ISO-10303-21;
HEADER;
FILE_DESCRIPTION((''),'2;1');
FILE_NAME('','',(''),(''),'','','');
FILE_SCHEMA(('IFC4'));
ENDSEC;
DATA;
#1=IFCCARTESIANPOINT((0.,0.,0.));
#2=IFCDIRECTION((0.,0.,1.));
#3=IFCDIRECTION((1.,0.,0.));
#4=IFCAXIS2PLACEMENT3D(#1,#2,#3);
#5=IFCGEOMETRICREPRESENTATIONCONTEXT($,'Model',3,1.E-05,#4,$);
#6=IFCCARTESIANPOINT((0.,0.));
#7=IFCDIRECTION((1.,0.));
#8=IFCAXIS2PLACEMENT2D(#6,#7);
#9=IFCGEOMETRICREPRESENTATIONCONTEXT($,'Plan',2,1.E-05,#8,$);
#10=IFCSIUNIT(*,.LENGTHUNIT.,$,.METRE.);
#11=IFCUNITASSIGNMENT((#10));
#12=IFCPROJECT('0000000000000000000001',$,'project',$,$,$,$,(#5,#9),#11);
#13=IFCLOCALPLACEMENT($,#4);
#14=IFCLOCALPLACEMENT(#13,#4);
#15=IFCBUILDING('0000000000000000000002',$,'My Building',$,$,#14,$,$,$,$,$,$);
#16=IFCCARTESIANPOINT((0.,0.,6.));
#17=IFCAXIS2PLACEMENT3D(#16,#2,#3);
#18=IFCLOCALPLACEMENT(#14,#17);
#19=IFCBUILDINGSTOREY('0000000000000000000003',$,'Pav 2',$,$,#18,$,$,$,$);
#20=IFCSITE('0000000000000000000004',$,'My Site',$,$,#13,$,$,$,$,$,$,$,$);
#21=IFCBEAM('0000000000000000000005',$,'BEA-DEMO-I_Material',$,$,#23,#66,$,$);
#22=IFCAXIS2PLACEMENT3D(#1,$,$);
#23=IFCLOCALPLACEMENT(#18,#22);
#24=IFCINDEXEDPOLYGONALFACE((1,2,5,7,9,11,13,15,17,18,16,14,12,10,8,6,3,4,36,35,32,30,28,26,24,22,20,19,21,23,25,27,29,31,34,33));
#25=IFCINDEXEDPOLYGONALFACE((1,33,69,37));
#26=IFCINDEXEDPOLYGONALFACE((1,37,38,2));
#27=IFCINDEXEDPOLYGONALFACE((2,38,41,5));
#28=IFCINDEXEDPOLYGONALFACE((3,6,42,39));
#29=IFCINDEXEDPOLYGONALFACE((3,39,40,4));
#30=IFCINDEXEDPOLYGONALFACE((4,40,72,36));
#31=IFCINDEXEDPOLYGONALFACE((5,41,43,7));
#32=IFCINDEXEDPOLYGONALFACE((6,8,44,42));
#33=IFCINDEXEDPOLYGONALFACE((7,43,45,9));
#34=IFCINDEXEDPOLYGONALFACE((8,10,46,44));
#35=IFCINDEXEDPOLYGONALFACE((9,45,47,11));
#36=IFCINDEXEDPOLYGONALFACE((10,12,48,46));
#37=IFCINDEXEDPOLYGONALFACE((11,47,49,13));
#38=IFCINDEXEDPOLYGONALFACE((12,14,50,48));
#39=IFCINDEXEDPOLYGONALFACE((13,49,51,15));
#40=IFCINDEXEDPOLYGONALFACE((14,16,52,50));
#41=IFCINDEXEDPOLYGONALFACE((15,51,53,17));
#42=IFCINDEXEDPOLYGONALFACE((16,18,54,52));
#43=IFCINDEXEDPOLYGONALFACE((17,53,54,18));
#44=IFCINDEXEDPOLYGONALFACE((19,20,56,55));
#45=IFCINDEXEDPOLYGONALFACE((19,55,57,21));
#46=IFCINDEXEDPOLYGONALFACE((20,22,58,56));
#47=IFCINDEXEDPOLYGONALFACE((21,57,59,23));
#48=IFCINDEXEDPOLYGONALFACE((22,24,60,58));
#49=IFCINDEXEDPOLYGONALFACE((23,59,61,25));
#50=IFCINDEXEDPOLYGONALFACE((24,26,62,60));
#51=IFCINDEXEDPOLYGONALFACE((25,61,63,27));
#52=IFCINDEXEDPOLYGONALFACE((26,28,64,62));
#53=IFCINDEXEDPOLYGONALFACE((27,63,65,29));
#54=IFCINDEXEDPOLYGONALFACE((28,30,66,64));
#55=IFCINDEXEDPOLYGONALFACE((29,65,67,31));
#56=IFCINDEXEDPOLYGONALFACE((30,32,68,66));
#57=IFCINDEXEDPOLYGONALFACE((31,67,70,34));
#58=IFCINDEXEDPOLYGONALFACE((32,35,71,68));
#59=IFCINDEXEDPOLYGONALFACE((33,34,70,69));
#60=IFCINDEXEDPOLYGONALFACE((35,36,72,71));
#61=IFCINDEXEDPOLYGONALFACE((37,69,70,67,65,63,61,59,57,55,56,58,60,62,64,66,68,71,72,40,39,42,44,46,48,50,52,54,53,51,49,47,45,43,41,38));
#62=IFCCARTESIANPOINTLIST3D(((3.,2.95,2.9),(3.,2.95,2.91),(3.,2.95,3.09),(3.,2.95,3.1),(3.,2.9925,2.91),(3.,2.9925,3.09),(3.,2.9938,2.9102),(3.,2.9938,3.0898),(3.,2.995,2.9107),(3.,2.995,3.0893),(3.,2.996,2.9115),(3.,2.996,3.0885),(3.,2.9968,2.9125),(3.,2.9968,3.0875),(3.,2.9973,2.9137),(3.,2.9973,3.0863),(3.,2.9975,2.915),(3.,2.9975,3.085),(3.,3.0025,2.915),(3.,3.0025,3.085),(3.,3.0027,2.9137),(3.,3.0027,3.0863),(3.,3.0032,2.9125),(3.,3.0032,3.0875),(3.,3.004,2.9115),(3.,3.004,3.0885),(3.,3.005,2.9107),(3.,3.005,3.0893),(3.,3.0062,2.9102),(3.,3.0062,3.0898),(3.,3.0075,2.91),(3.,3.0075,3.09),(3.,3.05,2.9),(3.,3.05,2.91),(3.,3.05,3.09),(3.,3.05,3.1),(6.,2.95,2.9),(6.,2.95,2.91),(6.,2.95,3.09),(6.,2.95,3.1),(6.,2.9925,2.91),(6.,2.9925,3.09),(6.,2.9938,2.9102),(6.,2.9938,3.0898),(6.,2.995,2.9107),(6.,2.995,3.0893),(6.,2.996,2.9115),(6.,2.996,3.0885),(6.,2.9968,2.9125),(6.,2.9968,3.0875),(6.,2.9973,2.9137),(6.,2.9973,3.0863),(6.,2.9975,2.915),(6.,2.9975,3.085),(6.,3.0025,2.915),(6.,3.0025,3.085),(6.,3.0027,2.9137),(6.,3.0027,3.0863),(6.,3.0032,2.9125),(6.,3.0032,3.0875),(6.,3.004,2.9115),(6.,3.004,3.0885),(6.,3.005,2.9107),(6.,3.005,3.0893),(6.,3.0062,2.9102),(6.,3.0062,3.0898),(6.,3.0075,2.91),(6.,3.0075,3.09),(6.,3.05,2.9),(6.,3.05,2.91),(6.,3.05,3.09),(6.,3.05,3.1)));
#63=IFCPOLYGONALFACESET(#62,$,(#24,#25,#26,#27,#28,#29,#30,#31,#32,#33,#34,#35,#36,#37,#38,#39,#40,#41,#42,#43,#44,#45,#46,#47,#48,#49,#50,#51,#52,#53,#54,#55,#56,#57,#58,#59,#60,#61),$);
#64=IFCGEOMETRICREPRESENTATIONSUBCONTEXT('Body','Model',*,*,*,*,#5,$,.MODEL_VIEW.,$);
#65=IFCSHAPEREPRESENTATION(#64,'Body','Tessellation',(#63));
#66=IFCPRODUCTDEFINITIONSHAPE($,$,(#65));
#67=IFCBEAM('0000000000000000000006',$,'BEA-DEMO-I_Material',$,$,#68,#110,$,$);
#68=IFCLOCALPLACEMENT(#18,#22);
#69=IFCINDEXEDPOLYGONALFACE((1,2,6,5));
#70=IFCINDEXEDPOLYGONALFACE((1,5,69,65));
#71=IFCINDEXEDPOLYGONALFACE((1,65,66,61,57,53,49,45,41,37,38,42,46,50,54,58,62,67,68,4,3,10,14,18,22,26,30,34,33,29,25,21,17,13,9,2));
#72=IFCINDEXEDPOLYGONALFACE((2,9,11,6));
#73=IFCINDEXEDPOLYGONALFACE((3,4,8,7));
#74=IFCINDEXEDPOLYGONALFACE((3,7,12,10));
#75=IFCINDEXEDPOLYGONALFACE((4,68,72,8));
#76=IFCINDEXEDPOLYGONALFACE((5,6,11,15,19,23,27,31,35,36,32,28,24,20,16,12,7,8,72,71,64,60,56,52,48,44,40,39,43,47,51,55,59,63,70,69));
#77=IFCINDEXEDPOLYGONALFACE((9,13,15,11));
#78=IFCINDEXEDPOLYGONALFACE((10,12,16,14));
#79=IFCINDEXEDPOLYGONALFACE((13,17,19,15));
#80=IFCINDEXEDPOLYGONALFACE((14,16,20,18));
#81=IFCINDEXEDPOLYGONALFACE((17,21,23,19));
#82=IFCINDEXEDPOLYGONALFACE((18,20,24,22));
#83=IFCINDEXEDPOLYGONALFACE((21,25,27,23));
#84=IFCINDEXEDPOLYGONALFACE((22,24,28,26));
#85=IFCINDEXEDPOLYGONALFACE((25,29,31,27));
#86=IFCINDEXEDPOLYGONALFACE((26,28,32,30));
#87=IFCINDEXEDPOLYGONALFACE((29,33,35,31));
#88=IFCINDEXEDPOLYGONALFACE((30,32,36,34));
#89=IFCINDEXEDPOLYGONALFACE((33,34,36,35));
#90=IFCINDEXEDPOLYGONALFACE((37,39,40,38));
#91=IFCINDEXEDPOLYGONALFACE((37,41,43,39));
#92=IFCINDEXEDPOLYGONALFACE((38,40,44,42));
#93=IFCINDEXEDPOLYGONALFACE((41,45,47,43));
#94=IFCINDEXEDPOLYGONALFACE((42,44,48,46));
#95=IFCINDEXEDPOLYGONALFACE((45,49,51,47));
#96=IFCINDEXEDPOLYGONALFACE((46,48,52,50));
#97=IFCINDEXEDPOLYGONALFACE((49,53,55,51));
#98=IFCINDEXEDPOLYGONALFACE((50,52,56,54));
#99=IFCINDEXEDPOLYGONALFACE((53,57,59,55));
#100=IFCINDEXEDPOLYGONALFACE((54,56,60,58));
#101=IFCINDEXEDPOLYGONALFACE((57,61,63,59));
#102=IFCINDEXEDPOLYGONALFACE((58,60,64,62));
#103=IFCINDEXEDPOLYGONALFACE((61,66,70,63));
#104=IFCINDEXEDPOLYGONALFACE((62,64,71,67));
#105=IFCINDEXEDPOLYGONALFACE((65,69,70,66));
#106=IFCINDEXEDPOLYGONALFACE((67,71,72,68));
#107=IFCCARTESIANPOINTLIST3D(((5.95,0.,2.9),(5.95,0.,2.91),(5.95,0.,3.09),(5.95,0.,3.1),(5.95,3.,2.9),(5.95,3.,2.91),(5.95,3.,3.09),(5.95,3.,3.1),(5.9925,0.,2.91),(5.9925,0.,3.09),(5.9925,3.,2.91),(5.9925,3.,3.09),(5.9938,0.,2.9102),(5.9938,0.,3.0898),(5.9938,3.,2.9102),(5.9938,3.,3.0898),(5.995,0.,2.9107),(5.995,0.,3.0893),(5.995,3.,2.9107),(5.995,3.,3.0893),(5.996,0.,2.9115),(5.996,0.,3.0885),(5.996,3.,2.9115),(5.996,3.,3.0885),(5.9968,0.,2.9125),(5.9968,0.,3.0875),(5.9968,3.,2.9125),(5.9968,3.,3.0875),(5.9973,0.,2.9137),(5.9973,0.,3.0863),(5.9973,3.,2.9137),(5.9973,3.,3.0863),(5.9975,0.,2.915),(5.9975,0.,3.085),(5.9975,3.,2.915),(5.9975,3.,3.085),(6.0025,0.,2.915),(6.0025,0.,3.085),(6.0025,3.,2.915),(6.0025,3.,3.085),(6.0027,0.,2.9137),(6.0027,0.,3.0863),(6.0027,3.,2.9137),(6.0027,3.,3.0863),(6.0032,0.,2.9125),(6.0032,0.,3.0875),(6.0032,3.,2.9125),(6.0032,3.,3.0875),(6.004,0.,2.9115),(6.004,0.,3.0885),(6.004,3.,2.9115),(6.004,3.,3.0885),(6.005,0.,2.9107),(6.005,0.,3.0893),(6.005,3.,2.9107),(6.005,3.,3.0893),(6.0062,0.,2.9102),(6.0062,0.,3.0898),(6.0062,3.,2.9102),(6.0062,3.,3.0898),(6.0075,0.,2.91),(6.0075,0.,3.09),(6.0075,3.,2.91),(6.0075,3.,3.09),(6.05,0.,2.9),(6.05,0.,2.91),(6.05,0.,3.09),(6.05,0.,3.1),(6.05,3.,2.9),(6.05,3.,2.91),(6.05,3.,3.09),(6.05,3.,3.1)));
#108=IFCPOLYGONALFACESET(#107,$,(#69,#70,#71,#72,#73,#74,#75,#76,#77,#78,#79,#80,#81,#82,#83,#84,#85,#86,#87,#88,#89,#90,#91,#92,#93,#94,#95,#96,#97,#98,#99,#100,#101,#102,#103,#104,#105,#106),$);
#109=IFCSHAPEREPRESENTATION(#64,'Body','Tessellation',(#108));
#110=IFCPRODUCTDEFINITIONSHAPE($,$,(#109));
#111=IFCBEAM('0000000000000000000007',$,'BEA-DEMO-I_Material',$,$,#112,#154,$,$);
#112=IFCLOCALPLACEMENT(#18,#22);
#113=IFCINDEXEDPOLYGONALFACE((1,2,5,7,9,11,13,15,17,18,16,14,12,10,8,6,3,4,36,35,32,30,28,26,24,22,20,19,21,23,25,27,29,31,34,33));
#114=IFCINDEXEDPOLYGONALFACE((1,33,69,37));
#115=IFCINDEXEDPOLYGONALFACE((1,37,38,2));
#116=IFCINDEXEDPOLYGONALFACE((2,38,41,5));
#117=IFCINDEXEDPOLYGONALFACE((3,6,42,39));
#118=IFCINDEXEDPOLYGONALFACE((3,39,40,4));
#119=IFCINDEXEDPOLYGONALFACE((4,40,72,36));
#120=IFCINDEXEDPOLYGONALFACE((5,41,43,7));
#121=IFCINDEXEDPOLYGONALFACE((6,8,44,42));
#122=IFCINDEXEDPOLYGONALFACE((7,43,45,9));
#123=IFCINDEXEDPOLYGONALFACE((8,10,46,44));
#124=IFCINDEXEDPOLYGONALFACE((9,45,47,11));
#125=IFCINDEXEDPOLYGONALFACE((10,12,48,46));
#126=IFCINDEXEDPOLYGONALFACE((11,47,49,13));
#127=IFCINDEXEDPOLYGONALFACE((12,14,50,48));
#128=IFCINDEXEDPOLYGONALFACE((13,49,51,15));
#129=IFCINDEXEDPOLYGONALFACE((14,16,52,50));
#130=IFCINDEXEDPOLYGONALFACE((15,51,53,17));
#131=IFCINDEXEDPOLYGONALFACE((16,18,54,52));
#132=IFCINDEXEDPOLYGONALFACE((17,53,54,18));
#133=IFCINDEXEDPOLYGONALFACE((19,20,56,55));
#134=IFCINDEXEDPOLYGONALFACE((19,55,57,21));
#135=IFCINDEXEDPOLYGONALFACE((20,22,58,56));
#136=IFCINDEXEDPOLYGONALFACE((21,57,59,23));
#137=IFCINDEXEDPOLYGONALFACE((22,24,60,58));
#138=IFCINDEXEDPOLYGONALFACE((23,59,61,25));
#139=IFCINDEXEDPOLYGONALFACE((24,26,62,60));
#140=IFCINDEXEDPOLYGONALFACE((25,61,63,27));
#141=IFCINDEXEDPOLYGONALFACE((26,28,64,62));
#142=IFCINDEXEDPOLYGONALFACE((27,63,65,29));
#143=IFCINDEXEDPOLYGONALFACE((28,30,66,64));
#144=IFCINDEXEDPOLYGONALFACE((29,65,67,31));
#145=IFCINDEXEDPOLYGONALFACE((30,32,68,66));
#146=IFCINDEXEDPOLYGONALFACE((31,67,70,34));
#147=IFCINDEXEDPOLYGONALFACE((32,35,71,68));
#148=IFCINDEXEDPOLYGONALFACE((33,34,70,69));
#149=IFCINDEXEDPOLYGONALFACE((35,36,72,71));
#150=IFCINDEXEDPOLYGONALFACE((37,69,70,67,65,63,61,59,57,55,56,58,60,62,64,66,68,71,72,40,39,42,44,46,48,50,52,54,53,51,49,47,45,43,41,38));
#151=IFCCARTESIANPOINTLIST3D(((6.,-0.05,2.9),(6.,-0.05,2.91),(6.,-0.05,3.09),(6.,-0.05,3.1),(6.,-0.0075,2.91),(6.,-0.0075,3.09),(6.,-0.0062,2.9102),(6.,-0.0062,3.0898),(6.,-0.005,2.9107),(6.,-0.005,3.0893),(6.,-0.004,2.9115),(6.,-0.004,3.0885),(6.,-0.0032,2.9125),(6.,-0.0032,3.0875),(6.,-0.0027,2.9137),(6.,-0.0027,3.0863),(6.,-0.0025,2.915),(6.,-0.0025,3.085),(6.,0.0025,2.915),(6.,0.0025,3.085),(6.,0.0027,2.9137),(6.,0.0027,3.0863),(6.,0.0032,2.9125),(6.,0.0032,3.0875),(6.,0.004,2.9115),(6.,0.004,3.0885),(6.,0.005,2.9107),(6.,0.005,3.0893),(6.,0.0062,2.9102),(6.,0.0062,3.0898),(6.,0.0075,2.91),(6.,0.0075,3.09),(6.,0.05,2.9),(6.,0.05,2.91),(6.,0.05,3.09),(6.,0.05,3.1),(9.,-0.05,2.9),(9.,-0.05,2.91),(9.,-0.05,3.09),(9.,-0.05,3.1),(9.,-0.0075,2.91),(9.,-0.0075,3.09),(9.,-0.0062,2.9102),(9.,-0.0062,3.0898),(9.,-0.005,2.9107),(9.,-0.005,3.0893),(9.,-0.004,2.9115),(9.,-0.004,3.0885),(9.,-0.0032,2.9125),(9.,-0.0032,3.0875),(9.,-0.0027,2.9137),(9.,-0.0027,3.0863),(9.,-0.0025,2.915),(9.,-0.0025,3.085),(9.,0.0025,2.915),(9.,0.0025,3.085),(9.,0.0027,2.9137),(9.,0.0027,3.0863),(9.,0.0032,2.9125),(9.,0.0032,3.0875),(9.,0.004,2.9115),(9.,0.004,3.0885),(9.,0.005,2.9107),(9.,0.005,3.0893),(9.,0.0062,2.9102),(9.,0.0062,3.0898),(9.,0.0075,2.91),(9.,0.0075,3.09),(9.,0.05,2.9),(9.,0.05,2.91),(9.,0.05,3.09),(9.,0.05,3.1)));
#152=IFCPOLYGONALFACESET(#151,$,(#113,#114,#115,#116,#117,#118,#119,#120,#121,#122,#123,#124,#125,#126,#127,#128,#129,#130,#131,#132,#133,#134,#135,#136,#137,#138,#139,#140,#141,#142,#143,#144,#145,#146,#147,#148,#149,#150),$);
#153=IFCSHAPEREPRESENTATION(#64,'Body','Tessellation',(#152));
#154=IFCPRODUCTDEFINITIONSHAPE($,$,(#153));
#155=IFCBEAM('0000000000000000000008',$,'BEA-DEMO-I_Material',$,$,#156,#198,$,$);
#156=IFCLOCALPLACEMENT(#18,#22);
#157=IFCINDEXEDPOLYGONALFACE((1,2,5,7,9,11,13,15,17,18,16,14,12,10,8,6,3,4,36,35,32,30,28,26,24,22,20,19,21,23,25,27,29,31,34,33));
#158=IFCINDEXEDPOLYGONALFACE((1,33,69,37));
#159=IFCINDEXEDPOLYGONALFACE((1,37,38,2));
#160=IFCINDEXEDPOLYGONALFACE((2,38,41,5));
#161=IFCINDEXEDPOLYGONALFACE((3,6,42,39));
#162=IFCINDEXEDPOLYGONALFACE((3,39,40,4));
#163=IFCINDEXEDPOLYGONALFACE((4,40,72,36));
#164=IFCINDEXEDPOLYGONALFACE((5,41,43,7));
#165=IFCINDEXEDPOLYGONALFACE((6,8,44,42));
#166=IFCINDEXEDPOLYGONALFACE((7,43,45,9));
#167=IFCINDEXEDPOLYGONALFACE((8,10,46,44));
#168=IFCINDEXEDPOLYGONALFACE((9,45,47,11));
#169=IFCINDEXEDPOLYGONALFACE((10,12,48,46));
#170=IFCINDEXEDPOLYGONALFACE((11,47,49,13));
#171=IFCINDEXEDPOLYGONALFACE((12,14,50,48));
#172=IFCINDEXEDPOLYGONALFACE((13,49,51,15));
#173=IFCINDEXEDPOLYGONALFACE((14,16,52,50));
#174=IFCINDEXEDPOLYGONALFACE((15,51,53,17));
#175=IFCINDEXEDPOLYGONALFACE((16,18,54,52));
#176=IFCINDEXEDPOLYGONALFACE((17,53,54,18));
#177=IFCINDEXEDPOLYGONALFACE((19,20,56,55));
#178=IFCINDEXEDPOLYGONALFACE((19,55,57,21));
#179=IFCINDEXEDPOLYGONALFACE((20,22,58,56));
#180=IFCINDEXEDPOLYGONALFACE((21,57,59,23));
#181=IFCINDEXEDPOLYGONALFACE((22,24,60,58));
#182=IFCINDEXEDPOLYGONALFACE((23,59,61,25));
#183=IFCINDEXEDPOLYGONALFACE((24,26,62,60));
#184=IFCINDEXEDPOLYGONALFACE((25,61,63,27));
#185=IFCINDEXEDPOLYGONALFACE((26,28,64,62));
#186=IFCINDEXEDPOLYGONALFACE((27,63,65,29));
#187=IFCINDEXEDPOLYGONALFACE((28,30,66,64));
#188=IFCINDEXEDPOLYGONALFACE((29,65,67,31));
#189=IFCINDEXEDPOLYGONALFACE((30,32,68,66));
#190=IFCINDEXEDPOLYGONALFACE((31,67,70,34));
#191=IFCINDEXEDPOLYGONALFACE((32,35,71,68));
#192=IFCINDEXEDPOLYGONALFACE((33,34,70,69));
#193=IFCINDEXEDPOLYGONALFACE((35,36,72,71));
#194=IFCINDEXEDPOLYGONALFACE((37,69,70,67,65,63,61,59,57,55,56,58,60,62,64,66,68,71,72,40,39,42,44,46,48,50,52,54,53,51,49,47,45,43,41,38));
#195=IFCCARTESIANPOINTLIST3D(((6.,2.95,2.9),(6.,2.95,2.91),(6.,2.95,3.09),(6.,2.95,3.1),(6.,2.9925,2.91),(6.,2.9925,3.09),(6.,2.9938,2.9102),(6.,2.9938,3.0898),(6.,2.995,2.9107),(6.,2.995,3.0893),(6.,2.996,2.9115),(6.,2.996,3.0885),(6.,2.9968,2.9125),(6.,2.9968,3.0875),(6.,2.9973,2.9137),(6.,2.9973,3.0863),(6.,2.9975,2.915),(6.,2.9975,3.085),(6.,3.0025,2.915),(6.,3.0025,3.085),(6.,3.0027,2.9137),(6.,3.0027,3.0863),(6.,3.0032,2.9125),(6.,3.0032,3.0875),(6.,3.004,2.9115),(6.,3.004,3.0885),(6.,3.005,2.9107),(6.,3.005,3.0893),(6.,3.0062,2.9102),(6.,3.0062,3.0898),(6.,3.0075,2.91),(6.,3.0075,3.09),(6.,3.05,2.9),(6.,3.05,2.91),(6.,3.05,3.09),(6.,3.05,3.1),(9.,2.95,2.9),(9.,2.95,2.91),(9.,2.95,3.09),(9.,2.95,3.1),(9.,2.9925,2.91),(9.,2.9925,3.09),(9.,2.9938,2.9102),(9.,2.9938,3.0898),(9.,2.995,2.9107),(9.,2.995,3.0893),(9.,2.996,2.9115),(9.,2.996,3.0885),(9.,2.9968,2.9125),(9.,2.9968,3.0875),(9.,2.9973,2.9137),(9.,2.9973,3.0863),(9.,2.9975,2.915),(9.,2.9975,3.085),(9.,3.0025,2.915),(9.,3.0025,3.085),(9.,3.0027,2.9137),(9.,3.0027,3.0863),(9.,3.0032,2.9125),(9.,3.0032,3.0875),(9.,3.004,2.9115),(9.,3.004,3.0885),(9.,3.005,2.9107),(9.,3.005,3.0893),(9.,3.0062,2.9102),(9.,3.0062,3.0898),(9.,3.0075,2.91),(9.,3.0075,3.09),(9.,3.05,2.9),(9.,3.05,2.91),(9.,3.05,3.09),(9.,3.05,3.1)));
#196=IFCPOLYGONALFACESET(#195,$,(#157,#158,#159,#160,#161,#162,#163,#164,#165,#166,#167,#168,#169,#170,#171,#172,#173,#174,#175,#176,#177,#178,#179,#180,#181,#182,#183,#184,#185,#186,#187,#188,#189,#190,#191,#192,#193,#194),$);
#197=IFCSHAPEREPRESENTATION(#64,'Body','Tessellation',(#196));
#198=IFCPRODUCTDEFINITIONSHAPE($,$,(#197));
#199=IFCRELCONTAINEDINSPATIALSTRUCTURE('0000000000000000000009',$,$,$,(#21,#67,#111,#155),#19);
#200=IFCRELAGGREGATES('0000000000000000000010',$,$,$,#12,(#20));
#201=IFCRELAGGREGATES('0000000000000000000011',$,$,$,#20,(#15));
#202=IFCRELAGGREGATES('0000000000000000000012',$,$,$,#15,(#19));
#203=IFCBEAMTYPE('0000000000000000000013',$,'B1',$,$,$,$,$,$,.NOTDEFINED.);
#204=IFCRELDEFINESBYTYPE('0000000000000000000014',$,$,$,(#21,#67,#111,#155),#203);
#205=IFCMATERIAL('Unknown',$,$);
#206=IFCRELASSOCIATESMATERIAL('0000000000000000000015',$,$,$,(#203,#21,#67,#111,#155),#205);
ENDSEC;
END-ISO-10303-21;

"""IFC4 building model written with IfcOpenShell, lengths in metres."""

from ifc_helpers import new_model, si_unit, frame, origin, origin_with_axes, origin_2d_with_axis, place, context, subcontext, project, spatial, i_section, extrude, material, material_profile, profile_set, profile_usage, type_object, element, save


model = new_model("IFC4")

# Units and contexts
model_context = context("Model", 3, precision=1e-05, world=origin_with_axes())
plan_context = context("Plan", 2, precision=1e-05, world=origin_2d_with_axis())
body_context = subcontext(model_context, "Body", "Model", "MODEL_VIEW")
ifc_project = project(units=[si_unit("LENGTHUNIT", "METRE")], contexts=[model_context, plan_context])

# Site, building, storey
site_placement = place(None, origin_with_axes())
site = spatial("IfcSite", under=ifc_project, at=site_placement, Name="My Site")
building_placement = place(site_placement, origin_with_axes())
building = spatial("IfcBuilding", under=site, at=building_placement, Name="My Building")
storey_placement = place(building_placement, frame((0.0, 0.0, 6.0), z_axis=(0.0, 0.0, 1.0), x_axis=(1.0, 0.0, 0.0)))
storey = spatial("IfcBuildingStorey", under=building, at=storey_placement, Name="Pav 2")

# Beams
ifc_material = material(Name="Unknown")
ifc_material_profile = material_profile(ifc_material, i_section(OverallWidth=0.1, OverallDepth=0.2, WebThickness=0.005, FlangeThickness=0.01, FilletRadius=0.005))
ifc_profile_set = profile_set([ifc_material_profile])
beam_type = type_object("IfcBeamType", Name="B1", PredefinedType="NOTDEFINED", material=ifc_profile_set)
ifc_profile_usage_1 = profile_usage(ifc_profile_set, cardinal=5)
beam_1_placement = place(storey_placement, frame((3.0, 3.0, 3.0), z_axis=(1.0, 0.0, 0.0), x_axis=(0.0, 1.0, 0.0)))
element("IfcBeam", 1, at=beam_1_placement, inside=storey, type_object=beam_type, material=ifc_profile_usage_1, Name="BEA-DEMO-I_Material", context=body_context, shape_type="SweptSolid", body=[
    extrude(i_section(OverallWidth=0.1, OverallDepth=0.2, WebThickness=0.005, FlangeThickness=0.01, FilletRadius=0.005), origin(), (0.0, 0.0, 1.0), 3.0),
])
ifc_profile_usage_2 = profile_usage(ifc_profile_set, cardinal=5)
beam_2_placement = place(storey_placement, frame((6.0, 3.0, 3.0), z_axis=(0.0, -1.0, 0.0), x_axis=(1.0, 0.0, 0.0)))
element("IfcBeam", 2, at=beam_2_placement, inside=storey, type_object=beam_type, material=ifc_profile_usage_2, Name="BEA-DEMO-I_Material", context=body_context, shape_type="SweptSolid", body=[
    extrude(i_section(OverallWidth=0.1, OverallDepth=0.2, WebThickness=0.005, FlangeThickness=0.01, FilletRadius=0.005), origin(), (0.0, 0.0, 1.0), 3.0),
])
ifc_profile_usage_3 = profile_usage(ifc_profile_set, cardinal=5)
beam_3_placement = place(storey_placement, frame((9.0, 0.0, 3.0), z_axis=(-1.0, 0.0, 0.0), x_axis=(0.0, -1.0, 0.0)))
element("IfcBeam", 3, at=beam_3_placement, inside=storey, type_object=beam_type, material=ifc_profile_usage_3, Name="BEA-DEMO-I_Material", context=body_context, shape_type="SweptSolid", body=[
    extrude(i_section(OverallWidth=0.1, OverallDepth=0.2, WebThickness=0.005, FlangeThickness=0.01, FilletRadius=0.005), origin(), (0.0, 0.0, 1.0), 3.0),
])
ifc_profile_usage_4 = profile_usage(ifc_profile_set, cardinal=5)
beam_4_placement = place(storey_placement, frame((6.0, 3.0, 3.0), z_axis=(1.0, 0.0, 0.0), x_axis=(0.0, 1.0, 0.0)))
element("IfcBeam", 4, at=beam_4_placement, inside=storey, type_object=beam_type, material=ifc_profile_usage_4, Name="BEA-DEMO-I_Material", context=body_context, shape_type="SweptSolid", body=[
    extrude(i_section(OverallWidth=0.1, OverallDepth=0.2, WebThickness=0.005, FlangeThickness=0.01, FilletRadius=0.005), origin(), (0.0, 0.0, 1.0), 3.0),
])

save(model, "model.ifc")
